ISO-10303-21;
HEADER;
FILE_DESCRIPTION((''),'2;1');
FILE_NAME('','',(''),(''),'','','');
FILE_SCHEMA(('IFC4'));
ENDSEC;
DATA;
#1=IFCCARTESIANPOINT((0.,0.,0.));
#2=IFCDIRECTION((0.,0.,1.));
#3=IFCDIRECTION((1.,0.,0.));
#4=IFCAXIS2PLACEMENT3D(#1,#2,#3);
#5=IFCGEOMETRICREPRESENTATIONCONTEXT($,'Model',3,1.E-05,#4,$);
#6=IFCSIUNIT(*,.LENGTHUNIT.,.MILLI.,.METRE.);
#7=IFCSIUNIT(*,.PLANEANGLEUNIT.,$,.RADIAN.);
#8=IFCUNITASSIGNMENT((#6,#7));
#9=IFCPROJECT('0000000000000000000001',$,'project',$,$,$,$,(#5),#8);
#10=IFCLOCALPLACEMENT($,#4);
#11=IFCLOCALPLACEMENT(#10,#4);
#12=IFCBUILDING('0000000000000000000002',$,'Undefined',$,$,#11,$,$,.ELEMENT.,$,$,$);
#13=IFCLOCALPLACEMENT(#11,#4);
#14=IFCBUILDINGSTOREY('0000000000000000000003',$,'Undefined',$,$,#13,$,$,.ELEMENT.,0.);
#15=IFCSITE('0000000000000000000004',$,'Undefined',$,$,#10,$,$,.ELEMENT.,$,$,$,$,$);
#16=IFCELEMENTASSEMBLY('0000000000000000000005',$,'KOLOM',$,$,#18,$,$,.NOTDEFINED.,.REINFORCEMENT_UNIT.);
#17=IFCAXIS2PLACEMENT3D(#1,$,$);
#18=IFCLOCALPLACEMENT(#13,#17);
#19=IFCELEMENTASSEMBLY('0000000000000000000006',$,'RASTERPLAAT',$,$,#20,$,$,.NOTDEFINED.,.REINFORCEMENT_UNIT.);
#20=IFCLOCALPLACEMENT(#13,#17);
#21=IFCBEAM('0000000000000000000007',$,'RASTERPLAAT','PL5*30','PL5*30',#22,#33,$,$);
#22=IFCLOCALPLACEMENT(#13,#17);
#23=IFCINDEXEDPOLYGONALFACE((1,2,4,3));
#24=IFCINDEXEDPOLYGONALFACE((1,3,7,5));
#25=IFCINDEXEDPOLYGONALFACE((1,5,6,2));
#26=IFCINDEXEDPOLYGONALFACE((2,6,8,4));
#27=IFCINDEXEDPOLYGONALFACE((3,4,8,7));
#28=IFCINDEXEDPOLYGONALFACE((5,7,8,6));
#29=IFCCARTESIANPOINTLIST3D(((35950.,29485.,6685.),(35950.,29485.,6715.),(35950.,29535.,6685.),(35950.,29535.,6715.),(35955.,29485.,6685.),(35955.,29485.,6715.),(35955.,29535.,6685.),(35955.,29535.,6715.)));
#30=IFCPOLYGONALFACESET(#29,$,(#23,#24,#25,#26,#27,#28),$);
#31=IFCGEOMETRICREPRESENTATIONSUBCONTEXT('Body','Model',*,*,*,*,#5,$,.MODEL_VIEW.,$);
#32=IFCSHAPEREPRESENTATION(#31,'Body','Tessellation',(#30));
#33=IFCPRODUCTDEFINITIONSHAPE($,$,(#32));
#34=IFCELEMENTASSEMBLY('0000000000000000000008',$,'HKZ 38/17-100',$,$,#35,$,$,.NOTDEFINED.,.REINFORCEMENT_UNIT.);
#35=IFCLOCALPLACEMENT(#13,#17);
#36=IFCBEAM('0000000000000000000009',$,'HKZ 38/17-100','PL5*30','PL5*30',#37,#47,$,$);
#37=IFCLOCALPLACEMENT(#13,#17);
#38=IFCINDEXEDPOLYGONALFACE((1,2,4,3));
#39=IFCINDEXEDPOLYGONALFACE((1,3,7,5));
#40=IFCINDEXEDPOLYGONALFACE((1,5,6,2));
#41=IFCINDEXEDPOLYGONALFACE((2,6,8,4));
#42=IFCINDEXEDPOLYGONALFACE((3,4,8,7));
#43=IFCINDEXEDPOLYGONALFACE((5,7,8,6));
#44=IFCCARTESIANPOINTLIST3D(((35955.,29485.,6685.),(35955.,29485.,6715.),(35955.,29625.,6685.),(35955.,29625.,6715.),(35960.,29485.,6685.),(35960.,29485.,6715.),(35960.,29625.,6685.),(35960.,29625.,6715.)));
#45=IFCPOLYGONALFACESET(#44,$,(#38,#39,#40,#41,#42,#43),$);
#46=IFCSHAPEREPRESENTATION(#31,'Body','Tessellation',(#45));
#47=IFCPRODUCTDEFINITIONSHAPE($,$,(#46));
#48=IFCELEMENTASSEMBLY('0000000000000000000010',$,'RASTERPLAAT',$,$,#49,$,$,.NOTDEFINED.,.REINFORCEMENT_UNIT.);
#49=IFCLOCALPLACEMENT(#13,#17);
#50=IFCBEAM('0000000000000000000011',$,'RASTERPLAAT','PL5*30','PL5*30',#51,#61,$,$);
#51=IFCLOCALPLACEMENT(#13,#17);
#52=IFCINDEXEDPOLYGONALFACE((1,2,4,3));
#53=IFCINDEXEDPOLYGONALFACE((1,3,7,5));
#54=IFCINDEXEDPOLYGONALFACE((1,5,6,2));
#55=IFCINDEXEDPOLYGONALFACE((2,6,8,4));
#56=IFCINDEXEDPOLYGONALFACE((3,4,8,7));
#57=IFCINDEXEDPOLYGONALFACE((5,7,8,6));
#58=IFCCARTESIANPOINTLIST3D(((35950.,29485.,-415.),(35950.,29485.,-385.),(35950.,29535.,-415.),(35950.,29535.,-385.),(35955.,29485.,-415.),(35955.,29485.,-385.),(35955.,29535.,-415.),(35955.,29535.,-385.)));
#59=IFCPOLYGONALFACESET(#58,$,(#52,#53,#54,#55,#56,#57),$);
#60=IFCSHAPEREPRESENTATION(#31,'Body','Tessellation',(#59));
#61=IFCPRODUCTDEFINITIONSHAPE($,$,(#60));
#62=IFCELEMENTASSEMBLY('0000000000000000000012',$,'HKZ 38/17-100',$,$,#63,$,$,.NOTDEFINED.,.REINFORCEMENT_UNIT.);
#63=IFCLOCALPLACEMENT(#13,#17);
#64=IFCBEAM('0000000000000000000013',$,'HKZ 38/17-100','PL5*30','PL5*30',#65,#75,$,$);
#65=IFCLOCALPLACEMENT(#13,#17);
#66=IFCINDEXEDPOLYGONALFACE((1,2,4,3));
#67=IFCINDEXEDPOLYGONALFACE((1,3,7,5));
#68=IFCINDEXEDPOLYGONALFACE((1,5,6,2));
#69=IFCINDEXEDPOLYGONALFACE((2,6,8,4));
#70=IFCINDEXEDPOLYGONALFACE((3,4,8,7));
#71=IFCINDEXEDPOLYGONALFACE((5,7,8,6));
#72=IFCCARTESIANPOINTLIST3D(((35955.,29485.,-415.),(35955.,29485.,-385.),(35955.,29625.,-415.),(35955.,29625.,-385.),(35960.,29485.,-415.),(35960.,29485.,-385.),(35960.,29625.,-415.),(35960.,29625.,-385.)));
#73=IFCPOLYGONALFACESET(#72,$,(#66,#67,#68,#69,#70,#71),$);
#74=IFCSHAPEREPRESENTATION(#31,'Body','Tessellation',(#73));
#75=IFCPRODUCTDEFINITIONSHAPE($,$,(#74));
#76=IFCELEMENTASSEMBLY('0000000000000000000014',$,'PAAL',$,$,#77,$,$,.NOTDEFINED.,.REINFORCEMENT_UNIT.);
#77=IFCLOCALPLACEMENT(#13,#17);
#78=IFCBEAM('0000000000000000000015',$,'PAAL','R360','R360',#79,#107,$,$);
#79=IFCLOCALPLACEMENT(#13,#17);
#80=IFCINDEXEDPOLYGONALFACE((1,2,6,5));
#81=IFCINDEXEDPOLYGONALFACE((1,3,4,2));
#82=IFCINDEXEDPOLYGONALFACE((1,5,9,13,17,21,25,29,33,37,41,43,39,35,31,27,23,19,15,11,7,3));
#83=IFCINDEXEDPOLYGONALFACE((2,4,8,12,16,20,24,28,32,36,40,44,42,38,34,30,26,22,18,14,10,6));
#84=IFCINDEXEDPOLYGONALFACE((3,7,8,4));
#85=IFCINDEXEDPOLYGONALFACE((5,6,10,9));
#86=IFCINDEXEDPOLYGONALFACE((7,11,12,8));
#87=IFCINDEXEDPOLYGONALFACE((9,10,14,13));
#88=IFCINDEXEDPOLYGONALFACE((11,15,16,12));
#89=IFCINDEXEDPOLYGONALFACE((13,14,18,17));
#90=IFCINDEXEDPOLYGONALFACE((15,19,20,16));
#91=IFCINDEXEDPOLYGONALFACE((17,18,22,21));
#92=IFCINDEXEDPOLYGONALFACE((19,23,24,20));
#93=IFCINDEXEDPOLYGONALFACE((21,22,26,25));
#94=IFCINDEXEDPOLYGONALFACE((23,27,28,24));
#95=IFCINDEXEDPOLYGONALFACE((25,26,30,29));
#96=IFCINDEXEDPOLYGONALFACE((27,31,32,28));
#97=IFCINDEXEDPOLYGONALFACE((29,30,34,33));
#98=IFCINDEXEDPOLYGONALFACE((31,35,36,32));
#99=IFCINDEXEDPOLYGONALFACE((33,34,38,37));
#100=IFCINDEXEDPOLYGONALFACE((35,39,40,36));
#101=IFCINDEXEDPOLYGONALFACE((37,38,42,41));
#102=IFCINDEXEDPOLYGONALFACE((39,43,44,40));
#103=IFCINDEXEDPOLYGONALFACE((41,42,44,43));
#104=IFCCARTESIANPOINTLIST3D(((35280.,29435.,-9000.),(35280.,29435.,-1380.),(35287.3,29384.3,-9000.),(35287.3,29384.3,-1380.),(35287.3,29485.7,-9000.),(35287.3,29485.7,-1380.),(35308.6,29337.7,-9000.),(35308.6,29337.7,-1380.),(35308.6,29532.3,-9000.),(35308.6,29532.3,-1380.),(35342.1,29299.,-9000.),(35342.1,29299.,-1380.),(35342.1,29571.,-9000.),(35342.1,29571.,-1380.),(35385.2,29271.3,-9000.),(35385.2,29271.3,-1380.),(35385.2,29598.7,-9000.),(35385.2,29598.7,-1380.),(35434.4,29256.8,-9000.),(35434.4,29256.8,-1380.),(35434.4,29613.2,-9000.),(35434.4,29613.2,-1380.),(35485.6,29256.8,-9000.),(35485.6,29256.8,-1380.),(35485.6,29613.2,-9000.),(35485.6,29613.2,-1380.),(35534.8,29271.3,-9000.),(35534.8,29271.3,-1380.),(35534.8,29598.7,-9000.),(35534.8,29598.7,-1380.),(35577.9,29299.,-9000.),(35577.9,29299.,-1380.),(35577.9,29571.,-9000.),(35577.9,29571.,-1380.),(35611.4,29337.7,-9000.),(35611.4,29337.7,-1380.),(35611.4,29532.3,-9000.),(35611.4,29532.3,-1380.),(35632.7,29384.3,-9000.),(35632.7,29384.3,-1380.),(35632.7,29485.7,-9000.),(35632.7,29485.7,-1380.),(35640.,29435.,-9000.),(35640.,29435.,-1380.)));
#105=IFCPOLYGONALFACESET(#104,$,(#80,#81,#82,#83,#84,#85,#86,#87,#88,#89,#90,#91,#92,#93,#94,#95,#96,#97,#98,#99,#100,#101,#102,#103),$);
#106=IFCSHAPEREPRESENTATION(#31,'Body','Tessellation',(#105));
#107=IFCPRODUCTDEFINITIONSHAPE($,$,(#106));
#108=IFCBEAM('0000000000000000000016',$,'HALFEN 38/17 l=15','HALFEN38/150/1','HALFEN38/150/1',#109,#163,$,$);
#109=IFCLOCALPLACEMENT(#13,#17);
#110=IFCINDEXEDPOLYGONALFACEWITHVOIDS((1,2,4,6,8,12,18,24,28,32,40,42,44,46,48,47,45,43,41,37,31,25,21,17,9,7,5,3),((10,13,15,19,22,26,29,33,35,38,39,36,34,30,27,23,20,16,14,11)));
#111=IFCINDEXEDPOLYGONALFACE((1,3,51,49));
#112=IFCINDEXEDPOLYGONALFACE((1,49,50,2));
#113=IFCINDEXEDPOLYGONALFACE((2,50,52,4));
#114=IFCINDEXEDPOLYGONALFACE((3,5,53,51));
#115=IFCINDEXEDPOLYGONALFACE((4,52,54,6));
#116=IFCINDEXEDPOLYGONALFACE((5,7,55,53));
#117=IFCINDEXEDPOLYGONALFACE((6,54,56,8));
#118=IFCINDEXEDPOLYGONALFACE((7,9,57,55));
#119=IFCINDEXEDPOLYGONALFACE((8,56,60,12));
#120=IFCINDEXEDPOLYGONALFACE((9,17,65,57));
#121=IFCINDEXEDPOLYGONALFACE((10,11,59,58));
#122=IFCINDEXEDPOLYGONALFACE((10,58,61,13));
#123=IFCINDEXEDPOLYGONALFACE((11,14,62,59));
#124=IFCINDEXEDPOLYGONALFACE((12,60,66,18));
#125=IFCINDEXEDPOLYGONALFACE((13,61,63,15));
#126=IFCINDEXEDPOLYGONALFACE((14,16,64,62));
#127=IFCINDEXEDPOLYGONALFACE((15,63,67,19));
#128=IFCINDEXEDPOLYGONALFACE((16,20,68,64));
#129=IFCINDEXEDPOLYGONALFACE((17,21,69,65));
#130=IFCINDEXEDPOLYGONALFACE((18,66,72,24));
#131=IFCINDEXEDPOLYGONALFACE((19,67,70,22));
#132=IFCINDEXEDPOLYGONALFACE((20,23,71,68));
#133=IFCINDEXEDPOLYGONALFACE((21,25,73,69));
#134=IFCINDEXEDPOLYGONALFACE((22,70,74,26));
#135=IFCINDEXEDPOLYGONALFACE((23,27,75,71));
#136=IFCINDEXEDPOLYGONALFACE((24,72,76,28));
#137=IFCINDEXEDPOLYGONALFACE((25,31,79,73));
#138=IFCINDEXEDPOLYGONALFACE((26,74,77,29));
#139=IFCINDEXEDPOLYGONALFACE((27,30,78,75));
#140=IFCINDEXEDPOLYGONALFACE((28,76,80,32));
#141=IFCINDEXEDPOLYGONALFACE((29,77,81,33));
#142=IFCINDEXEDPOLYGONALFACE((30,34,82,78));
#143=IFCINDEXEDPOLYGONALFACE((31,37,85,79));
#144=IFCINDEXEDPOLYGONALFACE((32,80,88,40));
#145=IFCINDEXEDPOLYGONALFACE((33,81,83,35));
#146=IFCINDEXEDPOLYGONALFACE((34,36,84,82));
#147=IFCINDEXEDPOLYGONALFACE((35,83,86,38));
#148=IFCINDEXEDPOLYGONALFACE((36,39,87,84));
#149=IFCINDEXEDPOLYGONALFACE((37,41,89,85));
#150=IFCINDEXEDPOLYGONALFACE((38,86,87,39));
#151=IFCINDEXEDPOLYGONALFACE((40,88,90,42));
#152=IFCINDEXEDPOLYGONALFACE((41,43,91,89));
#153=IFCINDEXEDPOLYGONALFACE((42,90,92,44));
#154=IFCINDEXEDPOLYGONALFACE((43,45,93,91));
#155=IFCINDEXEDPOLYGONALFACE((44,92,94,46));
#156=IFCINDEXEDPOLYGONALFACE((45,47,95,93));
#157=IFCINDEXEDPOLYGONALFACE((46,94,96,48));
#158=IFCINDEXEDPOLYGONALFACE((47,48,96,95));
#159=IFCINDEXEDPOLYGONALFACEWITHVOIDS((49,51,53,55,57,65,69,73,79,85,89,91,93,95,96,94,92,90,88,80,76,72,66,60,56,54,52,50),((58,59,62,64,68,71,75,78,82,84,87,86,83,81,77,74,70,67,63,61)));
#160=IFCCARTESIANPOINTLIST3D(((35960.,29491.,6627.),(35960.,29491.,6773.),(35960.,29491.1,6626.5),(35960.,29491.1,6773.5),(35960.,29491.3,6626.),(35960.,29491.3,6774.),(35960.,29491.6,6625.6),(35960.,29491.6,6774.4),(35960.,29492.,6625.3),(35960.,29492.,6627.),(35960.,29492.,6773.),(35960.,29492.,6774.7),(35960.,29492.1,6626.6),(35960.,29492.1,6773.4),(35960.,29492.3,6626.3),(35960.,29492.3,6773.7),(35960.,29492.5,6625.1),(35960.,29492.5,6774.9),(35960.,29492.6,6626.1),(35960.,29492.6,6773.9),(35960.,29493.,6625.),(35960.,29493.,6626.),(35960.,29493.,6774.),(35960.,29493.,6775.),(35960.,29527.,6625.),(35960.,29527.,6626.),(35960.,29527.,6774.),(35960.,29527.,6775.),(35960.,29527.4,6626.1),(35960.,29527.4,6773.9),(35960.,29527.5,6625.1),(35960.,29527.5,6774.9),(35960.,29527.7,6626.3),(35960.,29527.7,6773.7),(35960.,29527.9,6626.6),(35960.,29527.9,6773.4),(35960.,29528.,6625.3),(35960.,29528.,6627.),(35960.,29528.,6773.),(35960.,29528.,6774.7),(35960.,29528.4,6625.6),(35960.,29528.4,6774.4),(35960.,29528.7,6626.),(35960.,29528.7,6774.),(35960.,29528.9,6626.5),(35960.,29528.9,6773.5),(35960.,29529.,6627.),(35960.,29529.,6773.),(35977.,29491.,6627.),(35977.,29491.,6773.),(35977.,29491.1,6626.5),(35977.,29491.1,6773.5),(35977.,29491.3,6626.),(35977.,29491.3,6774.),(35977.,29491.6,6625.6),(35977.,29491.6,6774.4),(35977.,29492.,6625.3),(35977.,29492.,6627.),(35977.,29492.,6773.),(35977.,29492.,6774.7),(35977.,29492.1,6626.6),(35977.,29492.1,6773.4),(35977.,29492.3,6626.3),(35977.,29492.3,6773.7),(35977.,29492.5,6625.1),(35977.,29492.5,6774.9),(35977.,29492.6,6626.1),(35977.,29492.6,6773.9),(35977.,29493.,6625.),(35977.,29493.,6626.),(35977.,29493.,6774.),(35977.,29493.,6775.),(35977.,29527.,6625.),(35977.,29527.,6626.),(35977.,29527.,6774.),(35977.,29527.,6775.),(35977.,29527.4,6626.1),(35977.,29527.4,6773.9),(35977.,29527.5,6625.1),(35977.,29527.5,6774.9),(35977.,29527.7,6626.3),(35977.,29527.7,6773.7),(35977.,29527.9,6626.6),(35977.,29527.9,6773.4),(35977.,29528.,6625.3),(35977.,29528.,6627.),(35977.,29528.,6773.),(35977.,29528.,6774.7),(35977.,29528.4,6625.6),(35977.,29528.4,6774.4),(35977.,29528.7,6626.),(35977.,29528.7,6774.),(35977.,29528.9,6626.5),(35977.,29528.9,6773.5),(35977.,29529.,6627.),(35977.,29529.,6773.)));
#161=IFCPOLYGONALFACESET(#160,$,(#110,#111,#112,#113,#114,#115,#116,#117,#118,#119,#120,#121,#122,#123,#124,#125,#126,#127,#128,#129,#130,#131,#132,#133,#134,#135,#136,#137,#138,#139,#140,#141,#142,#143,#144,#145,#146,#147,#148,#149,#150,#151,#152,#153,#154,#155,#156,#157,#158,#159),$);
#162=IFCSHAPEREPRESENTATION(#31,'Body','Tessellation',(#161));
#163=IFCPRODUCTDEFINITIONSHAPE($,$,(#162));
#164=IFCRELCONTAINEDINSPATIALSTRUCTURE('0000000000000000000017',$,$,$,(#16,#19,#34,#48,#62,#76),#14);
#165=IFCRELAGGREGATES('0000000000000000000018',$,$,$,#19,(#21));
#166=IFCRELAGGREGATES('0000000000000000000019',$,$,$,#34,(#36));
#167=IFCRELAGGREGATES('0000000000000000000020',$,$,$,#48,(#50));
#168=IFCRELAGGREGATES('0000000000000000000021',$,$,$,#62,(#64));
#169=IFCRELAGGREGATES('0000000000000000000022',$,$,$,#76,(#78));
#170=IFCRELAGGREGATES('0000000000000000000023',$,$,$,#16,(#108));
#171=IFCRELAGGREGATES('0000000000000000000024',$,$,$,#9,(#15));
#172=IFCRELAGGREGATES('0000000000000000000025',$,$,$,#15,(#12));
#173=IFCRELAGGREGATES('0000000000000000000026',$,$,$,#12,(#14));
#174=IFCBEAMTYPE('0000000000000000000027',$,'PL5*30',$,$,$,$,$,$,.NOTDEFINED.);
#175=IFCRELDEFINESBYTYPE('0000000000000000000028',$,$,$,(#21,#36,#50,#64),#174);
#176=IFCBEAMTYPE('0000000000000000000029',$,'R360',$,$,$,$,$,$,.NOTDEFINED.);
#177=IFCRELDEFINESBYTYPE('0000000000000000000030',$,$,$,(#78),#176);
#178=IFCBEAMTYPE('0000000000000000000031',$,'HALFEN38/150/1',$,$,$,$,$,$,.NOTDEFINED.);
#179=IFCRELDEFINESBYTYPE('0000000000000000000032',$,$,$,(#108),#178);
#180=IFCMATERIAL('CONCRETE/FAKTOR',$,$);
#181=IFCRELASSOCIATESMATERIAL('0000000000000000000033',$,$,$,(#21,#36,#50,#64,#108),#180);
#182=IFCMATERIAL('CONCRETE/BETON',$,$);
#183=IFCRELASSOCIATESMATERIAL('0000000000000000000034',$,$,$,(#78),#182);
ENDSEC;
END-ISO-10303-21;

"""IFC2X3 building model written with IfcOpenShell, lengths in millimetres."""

from ifc_helpers import new_model, si_unit, frame, frame_2d, origin_with_axes, place, context, subcontext, project, spatial, rectangle, hollow_rectangle, circle, extrude, material, type_object, element, aggregate, save


model = new_model("IFC2X3")

# Units and contexts
model_context = context("Model", 3, precision=1e-05, world=origin_with_axes())
body_context = subcontext(model_context, "Body", "Model", "MODEL_VIEW")
ifc_project = project(units=[si_unit("LENGTHUNIT", "METRE", prefix="MILLI"), si_unit("PLANEANGLEUNIT", "RADIAN")], contexts=[model_context])

# Site, building, storey
site_placement = place(None, origin_with_axes())
site = spatial("IfcSite", under=ifc_project, at=site_placement, Name="Undefined", CompositionType="ELEMENT")
building_placement = place(site_placement, origin_with_axes())
building = spatial("IfcBuilding", under=site, at=building_placement, Name="Undefined", CompositionType="ELEMENT")
storey_placement = place(building_placement, origin_with_axes())
storey = spatial("IfcBuildingStorey", under=building, at=storey_placement, Name="Undefined", CompositionType="ELEMENT", Elevation=0.0)

# Shared definitions
ifc_material_1 = material(Name="CONCRETE/BETON")

# Shared definitions
ifc_material_2 = material(Name="CONCRETE/FAKTOR")

# Element assembly
assembly_1_placement = place(storey_placement, origin_with_axes())
assembly_1 = element("IfcElementAssembly", 1, at=assembly_1_placement, inside=storey, Name="KOLOM", AssemblyPlace="NOTDEFINED", PredefinedType="REINFORCEMENT_UNIT")

# Element assemblies, beams
assembly_2_placement = place(storey_placement, origin_with_axes())
assembly_2 = element("IfcElementAssembly", 2, at=assembly_2_placement, inside=storey, Name="RASTERPLAAT", AssemblyPlace="NOTDEFINED", PredefinedType="REINFORCEMENT_UNIT")
beam_type_1 = type_object("IfcBeamType", Name="PL5*30", PredefinedType="NOTDEFINED")
beam_1_placement = place(assembly_2_placement, frame((35952.5, 29485.0, 6700.0), z_axis=(0.0, 0.0, 1.0), x_axis=(0.0, 1.0, 0.0)))
beam_1 = element("IfcBeam", 3, at=beam_1_placement, type_object=beam_type_1, material=ifc_material_2, Name="RASTERPLAAT", Description="PL5*30", ObjectType="PL5*30", context=body_context, shape_type="SweptSolid", body=[
    extrude(rectangle(XDim=5.0, YDim=30.0, at=frame_2d((0.0, 0.0), x_axis=(1.0, 0.0))), frame((50.0, 0.0, 0.0), z_axis=(-1.0, 0.0, 0.0), x_axis=(0.0, -1.0, 0.0)), (0.0, 0.0, 1.0), 50.0),
])
aggregate(assembly_2, [beam_1])
assembly_3_placement = place(storey_placement, origin_with_axes())
assembly_3 = element("IfcElementAssembly", 4, at=assembly_3_placement, inside=storey, Name="HKZ 38/17-100", AssemblyPlace="NOTDEFINED", PredefinedType="REINFORCEMENT_UNIT")
beam_2_placement = place(assembly_3_placement, frame((35957.5, 29625.0, 6700.0), z_axis=(0.0, 0.0, 1.0), x_axis=(0.0, -1.0, 0.0)))
beam_2 = element("IfcBeam", 5, at=beam_2_placement, type_object=beam_type_1, material=ifc_material_2, Name="HKZ 38/17-100", Description="PL5*30", ObjectType="PL5*30", context=body_context, shape_type="SweptSolid", body=[
    extrude(rectangle(XDim=5.0, YDim=30.0, at=frame_2d((0.0, 0.0), x_axis=(1.0, 0.0))), frame((140.0, 0.0, 0.0), z_axis=(-1.0, 0.0, 0.0), x_axis=(0.0, -1.0, 0.0)), (0.0, 0.0, 1.0), 140.0),
])
aggregate(assembly_3, [beam_2])
assembly_4_placement = place(storey_placement, origin_with_axes())
assembly_4 = element("IfcElementAssembly", 6, at=assembly_4_placement, inside=storey, Name="RASTERPLAAT", AssemblyPlace="NOTDEFINED", PredefinedType="REINFORCEMENT_UNIT")
beam_3_placement = place(assembly_4_placement, frame((35952.5, 29485.0, -400.0), z_axis=(0.0, 0.0, 1.0), x_axis=(0.0, 1.0, 0.0)))
beam_3 = element("IfcBeam", 7, at=beam_3_placement, type_object=beam_type_1, material=ifc_material_2, Name="RASTERPLAAT", Description="PL5*30", ObjectType="PL5*30", context=body_context, shape_type="SweptSolid", body=[
    extrude(rectangle(XDim=5.0, YDim=30.0, at=frame_2d((0.0, 0.0), x_axis=(1.0, 0.0))), frame((50.0, 0.0, 0.0), z_axis=(-1.0, 0.0, 0.0), x_axis=(0.0, -1.0, 0.0)), (0.0, 0.0, 1.0), 50.0),
])
aggregate(assembly_4, [beam_3])
assembly_5_placement = place(storey_placement, origin_with_axes())
assembly_5 = element("IfcElementAssembly", 8, at=assembly_5_placement, inside=storey, Name="HKZ 38/17-100", AssemblyPlace="NOTDEFINED", PredefinedType="REINFORCEMENT_UNIT")
beam_4_placement = place(assembly_5_placement, frame((35957.5, 29625.0, -400.0), z_axis=(0.0, 0.0, 1.0), x_axis=(0.0, -1.0, 0.0)))
beam_4 = element("IfcBeam", 9, at=beam_4_placement, type_object=beam_type_1, material=ifc_material_2, Name="HKZ 38/17-100", Description="PL5*30", ObjectType="PL5*30", context=body_context, shape_type="SweptSolid", body=[
    extrude(rectangle(XDim=5.0, YDim=30.0, at=frame_2d((0.0, 0.0), x_axis=(1.0, 0.0))), frame((140.0, 0.0, 0.0), z_axis=(-1.0, 0.0, 0.0), x_axis=(0.0, -1.0, 0.0)), (0.0, 0.0, 1.0), 140.0),
])
aggregate(assembly_5, [beam_4])
assembly_6_placement = place(storey_placement, origin_with_axes())
assembly_6 = element("IfcElementAssembly", 10, at=assembly_6_placement, inside=storey, Name="PAAL", AssemblyPlace="NOTDEFINED", PredefinedType="REINFORCEMENT_UNIT")
beam_type_2 = type_object("IfcBeamType", Name="R360", PredefinedType="NOTDEFINED")
beam_5_placement = place(assembly_6_placement, frame((35460.0, 29435.0, -1380.0), z_axis=(0.0, -1.0, 0.0), x_axis=(0.0, 0.0, -1.0)))
beam_5 = element("IfcBeam", 11, at=beam_5_placement, type_object=beam_type_2, material=ifc_material_1, Name="PAAL", Description="R360", ObjectType="R360", context=body_context, shape_type="SweptSolid", body=[
    extrude(circle(Radius=180.0, at=frame_2d((0.0, 0.0), x_axis=(1.0, 0.0))), frame((7620.0, 0.0, 0.0), z_axis=(-1.0, 0.0, 0.0), x_axis=(0.0, -1.0, 0.0)), (0.0, 0.0, 1.0), 7620.0),
])
aggregate(assembly_6, [beam_5])

# Beam
beam_type_3 = type_object("IfcBeamType", Name="HALFEN38/150/1", PredefinedType="NOTDEFINED")
beam_6_placement = place(assembly_1_placement, frame((35960.0, 29510.0, 6700.0), z_axis=(0.0, -1.0, 0.0), x_axis=(1.0, 0.0, 0.0)))
beam_6 = element("IfcBeam", 12, at=beam_6_placement, type_object=beam_type_3, material=ifc_material_2, Name="HALFEN 38/17 l=15", Description="HALFEN38/150/1", ObjectType="HALFEN38/150/1", context=body_context, shape_type="SweptSolid", body=[
    extrude(hollow_rectangle(XDim=150.0, YDim=38.0, WallThickness=1.0, InnerFilletRadius=1.0, OuterFilletRadius=2.0, at=frame_2d((0.0, 0.0), x_axis=(1.0, 0.0))), frame((17.0, 0.0, 0.0), z_axis=(-1.0, 0.0, 0.0), x_axis=(0.0, -1.0, 0.0)), (0.0, 0.0, 1.0), 17.0),
])

aggregate(assembly_1, [beam_6])

save(model, "model.ifc")
